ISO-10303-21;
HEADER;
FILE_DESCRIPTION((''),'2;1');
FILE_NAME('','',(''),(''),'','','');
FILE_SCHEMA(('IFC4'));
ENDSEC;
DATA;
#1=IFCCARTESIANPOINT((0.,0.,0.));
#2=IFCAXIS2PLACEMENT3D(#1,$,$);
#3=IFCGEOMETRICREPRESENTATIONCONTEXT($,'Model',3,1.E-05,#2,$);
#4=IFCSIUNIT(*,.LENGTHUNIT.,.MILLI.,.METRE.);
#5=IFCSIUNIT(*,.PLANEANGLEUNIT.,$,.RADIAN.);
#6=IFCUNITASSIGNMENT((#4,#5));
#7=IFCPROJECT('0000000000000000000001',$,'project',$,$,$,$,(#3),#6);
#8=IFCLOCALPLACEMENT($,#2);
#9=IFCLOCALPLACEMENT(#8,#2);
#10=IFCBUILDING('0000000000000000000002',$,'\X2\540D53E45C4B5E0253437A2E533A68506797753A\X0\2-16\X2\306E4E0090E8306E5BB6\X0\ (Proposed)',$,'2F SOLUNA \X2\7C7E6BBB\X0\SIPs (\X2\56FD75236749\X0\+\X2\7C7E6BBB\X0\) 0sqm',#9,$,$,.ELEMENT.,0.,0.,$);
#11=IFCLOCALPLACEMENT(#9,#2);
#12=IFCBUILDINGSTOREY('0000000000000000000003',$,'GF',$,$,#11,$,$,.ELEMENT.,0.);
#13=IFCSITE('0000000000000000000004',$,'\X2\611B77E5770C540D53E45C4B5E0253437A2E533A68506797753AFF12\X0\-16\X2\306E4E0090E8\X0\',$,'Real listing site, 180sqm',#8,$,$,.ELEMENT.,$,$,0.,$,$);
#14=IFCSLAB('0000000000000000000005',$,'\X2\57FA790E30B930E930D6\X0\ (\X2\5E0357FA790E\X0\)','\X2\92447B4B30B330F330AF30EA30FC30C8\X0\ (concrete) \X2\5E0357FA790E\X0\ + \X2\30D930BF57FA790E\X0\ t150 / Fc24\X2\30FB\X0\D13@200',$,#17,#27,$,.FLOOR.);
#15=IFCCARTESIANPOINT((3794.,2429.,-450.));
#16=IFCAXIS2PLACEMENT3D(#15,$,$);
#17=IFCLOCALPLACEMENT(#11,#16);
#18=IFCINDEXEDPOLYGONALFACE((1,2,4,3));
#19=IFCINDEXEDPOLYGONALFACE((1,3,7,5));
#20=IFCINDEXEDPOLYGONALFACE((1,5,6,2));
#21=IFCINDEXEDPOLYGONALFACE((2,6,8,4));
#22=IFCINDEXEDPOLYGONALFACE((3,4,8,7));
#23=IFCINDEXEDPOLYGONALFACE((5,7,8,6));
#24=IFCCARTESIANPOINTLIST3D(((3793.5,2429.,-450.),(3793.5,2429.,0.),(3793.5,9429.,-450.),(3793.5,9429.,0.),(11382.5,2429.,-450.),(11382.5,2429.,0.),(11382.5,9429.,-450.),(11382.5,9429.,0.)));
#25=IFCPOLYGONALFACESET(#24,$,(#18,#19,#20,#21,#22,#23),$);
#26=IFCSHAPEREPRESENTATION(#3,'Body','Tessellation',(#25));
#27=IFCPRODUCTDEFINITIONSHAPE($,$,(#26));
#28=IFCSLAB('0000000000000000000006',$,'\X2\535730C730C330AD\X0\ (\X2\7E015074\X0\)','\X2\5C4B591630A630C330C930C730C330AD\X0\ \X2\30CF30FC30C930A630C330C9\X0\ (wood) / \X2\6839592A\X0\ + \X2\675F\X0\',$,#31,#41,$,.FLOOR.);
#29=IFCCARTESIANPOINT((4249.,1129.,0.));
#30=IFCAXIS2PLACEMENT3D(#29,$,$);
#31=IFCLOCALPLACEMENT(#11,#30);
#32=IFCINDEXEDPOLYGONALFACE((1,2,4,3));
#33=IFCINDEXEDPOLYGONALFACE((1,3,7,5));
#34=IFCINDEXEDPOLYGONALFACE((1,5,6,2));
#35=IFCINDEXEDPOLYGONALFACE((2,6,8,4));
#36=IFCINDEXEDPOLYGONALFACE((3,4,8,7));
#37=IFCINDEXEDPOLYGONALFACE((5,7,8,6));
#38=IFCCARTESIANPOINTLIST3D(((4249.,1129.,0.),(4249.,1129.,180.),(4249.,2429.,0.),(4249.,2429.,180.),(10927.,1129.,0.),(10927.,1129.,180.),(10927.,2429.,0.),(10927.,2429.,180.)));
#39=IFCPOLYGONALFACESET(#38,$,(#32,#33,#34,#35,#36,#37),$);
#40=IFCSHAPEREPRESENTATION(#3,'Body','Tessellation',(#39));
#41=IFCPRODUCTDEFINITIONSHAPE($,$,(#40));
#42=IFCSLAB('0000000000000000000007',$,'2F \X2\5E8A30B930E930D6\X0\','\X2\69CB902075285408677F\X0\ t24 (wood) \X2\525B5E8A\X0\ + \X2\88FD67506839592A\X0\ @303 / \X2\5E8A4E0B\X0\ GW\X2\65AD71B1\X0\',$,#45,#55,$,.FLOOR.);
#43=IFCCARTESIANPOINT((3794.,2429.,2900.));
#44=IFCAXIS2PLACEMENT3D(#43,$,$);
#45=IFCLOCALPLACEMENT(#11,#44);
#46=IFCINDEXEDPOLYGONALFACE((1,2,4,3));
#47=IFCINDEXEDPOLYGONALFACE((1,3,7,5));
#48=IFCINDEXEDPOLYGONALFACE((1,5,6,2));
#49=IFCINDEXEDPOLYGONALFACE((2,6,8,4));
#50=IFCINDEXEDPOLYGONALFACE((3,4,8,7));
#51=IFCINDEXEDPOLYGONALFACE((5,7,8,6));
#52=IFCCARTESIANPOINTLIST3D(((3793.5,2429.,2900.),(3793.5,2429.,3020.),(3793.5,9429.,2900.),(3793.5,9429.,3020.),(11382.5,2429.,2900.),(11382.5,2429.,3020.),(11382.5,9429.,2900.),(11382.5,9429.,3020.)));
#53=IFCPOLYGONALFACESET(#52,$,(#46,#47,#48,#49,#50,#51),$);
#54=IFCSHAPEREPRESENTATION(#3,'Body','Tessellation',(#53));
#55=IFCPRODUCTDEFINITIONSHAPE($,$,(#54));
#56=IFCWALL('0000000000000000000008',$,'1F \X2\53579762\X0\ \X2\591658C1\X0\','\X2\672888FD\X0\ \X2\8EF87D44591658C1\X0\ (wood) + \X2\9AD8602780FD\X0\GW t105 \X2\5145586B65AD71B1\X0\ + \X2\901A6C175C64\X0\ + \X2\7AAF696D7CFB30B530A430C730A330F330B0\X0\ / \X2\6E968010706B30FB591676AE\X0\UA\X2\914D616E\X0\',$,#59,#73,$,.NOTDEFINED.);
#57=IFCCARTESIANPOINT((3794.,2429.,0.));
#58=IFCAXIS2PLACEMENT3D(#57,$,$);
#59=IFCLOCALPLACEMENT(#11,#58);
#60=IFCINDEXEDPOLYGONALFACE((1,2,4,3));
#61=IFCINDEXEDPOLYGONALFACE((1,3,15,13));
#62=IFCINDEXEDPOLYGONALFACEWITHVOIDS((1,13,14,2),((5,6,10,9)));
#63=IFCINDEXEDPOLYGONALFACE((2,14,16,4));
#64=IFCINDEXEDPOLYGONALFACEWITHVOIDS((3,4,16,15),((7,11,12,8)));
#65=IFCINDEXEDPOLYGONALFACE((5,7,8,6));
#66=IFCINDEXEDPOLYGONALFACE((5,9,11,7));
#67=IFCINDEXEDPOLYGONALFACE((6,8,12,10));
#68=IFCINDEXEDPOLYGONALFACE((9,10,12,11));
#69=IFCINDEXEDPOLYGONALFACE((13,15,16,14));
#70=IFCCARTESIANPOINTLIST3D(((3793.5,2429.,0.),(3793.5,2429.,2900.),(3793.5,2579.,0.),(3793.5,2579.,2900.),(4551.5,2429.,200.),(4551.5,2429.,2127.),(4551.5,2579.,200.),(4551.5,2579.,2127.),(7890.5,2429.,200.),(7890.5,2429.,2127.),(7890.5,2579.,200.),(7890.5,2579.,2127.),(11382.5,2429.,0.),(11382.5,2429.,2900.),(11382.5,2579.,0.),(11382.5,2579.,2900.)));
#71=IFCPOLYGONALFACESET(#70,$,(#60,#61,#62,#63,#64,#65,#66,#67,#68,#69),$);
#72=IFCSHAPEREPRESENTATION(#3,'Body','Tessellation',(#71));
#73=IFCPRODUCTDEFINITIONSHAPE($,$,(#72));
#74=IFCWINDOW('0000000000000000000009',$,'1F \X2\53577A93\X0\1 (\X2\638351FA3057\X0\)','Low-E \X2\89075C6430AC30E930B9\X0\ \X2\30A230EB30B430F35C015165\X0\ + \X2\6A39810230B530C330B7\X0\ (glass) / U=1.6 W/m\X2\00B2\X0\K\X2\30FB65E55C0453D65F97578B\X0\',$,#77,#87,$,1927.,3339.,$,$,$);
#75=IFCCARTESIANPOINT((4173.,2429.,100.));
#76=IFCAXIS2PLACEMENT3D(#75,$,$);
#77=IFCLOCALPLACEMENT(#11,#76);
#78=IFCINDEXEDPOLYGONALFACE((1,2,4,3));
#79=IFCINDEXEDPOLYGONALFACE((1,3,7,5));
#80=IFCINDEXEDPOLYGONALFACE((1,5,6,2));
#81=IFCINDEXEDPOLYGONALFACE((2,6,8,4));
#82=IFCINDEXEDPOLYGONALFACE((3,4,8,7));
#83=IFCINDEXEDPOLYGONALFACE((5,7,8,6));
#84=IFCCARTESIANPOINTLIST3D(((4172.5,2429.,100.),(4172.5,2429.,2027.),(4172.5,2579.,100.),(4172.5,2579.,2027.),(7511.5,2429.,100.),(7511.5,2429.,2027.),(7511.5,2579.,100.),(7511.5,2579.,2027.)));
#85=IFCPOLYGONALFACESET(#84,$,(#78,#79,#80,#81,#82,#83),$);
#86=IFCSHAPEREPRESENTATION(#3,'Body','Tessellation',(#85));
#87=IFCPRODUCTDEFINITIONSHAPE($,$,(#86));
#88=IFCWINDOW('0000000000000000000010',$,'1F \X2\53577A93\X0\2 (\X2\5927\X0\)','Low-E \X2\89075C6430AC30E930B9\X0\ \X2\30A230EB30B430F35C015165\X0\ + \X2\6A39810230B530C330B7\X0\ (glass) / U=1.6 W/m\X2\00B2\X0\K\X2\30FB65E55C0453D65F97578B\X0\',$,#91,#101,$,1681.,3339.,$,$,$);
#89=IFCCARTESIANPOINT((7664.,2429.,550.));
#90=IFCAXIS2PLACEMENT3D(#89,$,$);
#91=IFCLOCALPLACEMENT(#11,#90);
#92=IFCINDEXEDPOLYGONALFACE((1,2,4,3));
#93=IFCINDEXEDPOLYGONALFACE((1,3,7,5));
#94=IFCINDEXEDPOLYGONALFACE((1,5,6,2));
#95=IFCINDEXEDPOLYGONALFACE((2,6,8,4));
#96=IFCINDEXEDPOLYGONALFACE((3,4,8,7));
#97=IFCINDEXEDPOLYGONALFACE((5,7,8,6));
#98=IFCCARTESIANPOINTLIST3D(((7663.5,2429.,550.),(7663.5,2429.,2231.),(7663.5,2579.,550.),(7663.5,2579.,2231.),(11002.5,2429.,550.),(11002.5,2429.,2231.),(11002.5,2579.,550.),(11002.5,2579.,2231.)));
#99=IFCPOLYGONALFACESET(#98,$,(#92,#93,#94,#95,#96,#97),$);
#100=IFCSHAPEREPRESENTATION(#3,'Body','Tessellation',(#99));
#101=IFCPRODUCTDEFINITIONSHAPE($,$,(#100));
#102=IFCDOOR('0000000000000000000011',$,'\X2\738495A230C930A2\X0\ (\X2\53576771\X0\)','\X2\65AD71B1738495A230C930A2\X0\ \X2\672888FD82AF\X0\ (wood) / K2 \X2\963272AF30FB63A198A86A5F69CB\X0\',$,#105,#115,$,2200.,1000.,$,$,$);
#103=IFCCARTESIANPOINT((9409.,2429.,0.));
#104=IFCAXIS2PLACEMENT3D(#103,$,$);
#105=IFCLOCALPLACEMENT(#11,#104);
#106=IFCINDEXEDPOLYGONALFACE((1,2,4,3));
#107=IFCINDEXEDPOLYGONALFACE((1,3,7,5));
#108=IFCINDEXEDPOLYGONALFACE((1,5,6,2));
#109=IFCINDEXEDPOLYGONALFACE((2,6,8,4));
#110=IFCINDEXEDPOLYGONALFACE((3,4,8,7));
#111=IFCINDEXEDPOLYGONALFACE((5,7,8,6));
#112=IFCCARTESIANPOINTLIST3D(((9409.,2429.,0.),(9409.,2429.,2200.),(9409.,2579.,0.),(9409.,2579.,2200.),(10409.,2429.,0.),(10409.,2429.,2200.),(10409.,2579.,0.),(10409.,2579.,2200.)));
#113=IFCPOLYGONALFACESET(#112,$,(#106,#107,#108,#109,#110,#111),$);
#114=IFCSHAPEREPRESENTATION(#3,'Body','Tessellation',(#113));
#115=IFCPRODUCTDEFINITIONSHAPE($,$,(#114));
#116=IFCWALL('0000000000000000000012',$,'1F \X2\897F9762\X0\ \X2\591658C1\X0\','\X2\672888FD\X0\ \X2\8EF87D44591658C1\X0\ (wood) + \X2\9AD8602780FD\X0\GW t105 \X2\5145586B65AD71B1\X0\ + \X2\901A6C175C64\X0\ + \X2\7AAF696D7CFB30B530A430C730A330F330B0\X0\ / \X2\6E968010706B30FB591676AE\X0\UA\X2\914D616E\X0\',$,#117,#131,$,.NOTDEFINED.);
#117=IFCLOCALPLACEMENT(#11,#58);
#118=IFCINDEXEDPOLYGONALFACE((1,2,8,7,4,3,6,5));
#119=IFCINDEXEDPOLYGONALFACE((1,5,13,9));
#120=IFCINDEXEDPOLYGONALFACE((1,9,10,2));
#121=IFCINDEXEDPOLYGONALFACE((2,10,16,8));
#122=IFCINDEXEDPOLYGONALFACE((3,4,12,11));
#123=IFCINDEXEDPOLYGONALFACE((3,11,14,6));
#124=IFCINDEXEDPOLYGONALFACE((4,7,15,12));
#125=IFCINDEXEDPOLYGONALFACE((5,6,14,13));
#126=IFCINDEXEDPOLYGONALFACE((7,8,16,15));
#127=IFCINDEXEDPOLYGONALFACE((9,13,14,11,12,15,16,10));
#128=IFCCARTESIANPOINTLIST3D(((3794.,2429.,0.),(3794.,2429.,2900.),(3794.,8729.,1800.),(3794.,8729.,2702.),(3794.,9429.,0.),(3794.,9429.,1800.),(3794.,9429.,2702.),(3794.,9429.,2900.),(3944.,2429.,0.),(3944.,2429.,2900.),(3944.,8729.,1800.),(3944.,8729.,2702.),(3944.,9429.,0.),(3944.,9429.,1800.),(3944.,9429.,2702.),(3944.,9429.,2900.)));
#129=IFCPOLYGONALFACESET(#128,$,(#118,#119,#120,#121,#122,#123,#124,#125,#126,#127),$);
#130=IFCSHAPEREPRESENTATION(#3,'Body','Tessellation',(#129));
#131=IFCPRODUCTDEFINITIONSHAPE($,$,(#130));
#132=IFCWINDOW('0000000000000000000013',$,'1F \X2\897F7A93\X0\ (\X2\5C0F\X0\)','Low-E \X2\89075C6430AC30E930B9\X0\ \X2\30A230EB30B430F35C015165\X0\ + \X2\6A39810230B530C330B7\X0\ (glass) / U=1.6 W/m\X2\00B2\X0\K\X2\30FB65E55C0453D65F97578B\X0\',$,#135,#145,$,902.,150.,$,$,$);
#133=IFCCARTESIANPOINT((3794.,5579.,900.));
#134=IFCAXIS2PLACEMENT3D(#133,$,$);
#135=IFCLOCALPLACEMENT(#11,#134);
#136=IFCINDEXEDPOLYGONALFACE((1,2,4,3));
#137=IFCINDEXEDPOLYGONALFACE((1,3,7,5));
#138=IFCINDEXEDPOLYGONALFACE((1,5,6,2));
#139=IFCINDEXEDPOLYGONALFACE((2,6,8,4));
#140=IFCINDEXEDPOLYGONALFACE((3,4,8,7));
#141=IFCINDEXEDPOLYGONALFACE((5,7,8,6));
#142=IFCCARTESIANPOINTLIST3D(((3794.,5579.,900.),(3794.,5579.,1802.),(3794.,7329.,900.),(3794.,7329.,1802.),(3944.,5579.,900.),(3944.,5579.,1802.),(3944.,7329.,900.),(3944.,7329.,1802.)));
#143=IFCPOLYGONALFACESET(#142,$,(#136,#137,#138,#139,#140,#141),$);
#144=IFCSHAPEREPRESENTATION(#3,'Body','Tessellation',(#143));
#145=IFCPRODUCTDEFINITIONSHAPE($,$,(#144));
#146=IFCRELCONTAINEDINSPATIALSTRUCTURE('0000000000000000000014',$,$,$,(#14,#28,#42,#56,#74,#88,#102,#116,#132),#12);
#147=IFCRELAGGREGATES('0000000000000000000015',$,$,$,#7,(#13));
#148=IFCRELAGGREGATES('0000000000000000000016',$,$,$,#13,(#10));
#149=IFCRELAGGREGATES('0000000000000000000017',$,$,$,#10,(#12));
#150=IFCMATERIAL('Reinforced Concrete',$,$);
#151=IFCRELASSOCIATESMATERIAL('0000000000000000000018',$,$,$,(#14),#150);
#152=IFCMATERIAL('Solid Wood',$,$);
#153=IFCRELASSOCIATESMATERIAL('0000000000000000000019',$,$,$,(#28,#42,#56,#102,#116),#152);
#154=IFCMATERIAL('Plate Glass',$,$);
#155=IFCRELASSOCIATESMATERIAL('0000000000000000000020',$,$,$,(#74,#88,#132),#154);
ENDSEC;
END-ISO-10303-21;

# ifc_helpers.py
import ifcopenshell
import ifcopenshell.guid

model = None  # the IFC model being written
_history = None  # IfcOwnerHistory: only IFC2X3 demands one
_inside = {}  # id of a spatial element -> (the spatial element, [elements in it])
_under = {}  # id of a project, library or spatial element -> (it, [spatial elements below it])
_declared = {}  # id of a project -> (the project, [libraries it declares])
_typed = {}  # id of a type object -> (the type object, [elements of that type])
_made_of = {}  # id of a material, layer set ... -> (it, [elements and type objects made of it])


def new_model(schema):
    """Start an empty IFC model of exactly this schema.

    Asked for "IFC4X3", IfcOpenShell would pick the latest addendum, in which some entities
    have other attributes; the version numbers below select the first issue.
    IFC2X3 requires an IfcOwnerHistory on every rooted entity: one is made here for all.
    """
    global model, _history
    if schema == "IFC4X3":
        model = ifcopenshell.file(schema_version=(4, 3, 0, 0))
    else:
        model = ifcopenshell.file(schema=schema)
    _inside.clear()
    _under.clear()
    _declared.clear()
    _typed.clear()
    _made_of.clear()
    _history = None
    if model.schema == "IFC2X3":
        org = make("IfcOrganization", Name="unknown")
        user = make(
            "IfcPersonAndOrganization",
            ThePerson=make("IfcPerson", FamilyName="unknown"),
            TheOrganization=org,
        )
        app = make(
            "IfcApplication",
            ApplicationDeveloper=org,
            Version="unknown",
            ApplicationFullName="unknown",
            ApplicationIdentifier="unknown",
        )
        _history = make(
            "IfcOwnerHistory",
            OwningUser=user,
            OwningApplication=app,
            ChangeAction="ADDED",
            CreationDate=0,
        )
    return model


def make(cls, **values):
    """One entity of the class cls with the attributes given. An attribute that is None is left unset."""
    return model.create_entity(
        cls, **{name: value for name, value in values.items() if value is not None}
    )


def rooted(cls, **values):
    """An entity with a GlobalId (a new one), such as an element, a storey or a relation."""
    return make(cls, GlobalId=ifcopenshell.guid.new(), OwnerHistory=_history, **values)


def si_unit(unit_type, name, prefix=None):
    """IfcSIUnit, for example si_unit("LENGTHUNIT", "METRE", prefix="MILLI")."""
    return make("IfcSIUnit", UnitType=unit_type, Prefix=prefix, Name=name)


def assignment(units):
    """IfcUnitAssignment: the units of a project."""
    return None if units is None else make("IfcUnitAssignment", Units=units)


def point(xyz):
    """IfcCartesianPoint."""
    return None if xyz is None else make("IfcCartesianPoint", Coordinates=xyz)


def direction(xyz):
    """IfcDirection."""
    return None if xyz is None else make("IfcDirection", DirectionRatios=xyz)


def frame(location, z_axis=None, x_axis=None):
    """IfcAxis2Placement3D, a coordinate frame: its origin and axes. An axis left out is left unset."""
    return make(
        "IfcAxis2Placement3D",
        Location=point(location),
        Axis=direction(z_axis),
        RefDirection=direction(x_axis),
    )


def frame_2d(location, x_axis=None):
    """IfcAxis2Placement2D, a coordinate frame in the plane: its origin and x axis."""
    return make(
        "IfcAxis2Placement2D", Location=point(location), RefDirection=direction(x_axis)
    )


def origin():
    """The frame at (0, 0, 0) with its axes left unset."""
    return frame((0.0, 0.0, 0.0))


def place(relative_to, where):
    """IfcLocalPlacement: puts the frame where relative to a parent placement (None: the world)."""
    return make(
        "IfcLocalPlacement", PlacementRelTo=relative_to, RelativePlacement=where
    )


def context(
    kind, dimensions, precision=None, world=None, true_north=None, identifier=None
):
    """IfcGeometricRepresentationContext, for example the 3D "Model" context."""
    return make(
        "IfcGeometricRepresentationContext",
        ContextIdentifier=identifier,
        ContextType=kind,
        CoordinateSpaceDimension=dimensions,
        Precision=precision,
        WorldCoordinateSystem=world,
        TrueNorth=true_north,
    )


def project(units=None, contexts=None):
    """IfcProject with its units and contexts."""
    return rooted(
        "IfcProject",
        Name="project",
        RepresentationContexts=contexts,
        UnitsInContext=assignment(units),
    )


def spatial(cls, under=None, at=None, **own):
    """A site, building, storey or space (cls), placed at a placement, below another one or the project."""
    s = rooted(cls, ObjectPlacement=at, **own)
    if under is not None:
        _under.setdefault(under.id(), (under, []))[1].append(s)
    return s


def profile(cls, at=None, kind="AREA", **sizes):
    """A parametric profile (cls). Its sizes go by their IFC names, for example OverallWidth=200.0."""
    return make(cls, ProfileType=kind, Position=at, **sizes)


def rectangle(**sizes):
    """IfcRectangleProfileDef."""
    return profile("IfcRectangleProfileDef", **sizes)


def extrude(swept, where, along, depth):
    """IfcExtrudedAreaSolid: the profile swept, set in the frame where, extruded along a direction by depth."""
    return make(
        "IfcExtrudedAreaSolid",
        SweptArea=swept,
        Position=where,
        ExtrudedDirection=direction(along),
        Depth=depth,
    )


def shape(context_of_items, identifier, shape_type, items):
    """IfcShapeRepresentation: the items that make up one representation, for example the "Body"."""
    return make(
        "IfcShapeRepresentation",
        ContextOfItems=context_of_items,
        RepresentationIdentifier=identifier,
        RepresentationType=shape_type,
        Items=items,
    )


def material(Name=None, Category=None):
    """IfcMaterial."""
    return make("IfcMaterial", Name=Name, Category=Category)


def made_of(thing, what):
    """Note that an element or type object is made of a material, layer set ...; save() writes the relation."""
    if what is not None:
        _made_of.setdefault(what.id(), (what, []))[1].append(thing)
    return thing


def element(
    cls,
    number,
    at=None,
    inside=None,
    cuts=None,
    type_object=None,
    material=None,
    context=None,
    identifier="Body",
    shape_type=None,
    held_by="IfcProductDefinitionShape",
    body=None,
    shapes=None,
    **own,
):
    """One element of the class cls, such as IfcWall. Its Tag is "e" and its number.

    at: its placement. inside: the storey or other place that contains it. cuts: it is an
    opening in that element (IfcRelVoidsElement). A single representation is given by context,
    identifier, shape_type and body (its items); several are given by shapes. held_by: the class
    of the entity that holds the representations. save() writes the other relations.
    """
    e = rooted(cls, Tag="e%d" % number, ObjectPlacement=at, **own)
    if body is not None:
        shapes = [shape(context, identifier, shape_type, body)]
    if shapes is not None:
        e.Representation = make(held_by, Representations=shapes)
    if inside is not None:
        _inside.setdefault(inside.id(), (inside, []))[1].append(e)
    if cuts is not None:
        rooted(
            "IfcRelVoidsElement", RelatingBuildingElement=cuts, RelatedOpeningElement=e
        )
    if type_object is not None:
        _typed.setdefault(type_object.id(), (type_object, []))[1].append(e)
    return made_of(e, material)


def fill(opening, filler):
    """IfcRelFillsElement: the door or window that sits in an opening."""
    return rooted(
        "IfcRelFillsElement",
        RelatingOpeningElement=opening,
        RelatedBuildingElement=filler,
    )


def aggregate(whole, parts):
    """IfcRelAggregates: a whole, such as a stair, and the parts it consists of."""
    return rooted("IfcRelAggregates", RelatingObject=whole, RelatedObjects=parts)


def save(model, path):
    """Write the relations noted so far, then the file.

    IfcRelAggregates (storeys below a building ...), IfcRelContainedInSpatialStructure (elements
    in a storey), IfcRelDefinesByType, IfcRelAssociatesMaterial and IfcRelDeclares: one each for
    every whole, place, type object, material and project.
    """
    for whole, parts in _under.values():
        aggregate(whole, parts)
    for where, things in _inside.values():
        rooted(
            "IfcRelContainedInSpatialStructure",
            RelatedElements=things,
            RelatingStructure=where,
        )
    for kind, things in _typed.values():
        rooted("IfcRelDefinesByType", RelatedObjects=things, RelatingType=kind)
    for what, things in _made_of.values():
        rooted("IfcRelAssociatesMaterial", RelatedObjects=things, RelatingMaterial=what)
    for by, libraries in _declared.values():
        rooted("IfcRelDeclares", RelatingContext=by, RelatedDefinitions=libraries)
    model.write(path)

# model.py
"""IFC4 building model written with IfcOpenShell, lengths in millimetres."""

from ifc_helpers import new_model, si_unit, frame, frame_2d, origin, place, context, project, spatial, rectangle, extrude, material, element, fill, save


model = new_model("IFC4")

# Units and contexts
model_context = context("Model", 3, precision=1e-05, world=origin())
ifc_project = project(units=[si_unit("LENGTHUNIT", "METRE", prefix="MILLI"), si_unit("PLANEANGLEUNIT", "RADIAN")], contexts=[model_context])

# Site, building, storey
site_placement = place(None, origin())
site = spatial("IfcSite", under=ifc_project, at=site_placement, Name="愛知県名古屋市千種区桐林町２-16の一部", ObjectType="Real listing site, 180sqm", CompositionType="ELEMENT", RefElevation=0.0)
building_placement = place(site_placement, origin())
building = spatial("IfcBuilding", under=site, at=building_placement, Name="名古屋市千種区桐林町2-16の一部の家 (Proposed)", ObjectType="2F SOLUNA 籾殻SIPs (国産杉+籾殻) 0sqm", CompositionType="ELEMENT", ElevationOfRefHeight=0.0, ElevationOfTerrain=0.0)
storey_placement = place(building_placement, origin())
storey = spatial("IfcBuildingStorey", under=building, at=storey_placement, Name="GF", CompositionType="ELEMENT", Elevation=0.0)

# Slabs
ifc_material_1 = material(Name="Reinforced Concrete")
slab_1_placement = place(storey_placement, frame((3794.0, 2429.0, -450.0)))
element("IfcSlab", 1, at=slab_1_placement, inside=storey, material=ifc_material_1, Name="基礎スラブ (布基礎)", Description="鉄筋コンクリート (concrete) 布基礎 + ベタ基礎 t150 / Fc24・D13@200", PredefinedType="FLOOR", context=model_context, shape_type="SweptSolid", body=[
    extrude(rectangle(XDim=7589.0, YDim=7000.0, at=frame_2d((3794.0, 3500.0))), frame((3794.0, 2429.0, -450.0)), (0.0, 0.0, 1.0), 450.0),
])
ifc_material_2 = material(Name="Solid Wood")
slab_2_placement = place(storey_placement, frame((4249.0, 1129.0, 0.0)))
element("IfcSlab", 2, at=slab_2_placement, inside=storey, material=ifc_material_2, Name="南デッキ (縁側)", Description="屋外ウッドデッキ ハードウッド (wood) / 根太 + 束", PredefinedType="FLOOR", context=model_context, shape_type="SweptSolid", body=[
    extrude(rectangle(XDim=6678.0, YDim=1300.0, at=frame_2d((3339.0, 650.0))), frame((4249.0, 1129.0, 0.0)), (0.0, 0.0, 1.0), 180.0),
])
slab_3_placement = place(storey_placement, frame((3794.0, 2429.0, 2900.0)))
element("IfcSlab", 3, at=slab_3_placement, inside=storey, material=ifc_material_2, Name="2F 床スラブ", Description="構造用合板 t24 (wood) 剛床 + 製材根太 @303 / 床下 GW断熱", PredefinedType="FLOOR", context=model_context, shape_type="SweptSolid", body=[
    extrude(rectangle(XDim=7589.0, YDim=7000.0, at=frame_2d((3794.0, 3500.0))), frame((3794.0, 2429.0, 2900.0)), (0.0, 0.0, 1.0), 120.0),
])

# Wall, openings, windows, door
wall_1_placement = place(storey_placement, frame((3794.0, 2429.0, 0.0)))
wall_1 = element("IfcWall", 4, at=wall_1_placement, inside=storey, material=ifc_material_2, Name="1F 南面 外壁", Description="木製 軸組外壁 (wood) + 高性能GW t105 充填断熱 + 通気層 + 窯業系サイディング / 準耐火・外皮UA配慮", PredefinedType="NOTDEFINED", context=model_context, shape_type="SweptSolid", body=[
    extrude(rectangle(XDim=7589.0, YDim=150.0, at=frame_2d((3794.0, 75.0))), frame((3794.0, 2429.0, 0.0)), (0.0, 0.0, 1.0), 2900.0),
])
opening_1_placement = place(storey_placement, frame((4173.0, 2429.0, 100.0)))
opening_1 = element("IfcOpeningElement", 5, at=opening_1_placement, cuts=wall_1, PredefinedType="NOTDEFINED", context=model_context, shape_type="SweptSolid", body=[
    extrude(rectangle(XDim=3339.0, YDim=150.0, at=frame_2d((1669.0, 75.0))), frame((4173.0, 2429.0, 100.0)), (0.0, 0.0, 1.0), 1927.0),
])
opening_2_placement = place(storey_placement, frame((7664.0, 2429.0, 550.0)))
opening_2 = element("IfcOpeningElement", 6, at=opening_2_placement, cuts=wall_1, PredefinedType="NOTDEFINED", context=model_context, shape_type="SweptSolid", body=[
    extrude(rectangle(XDim=3339.0, YDim=150.0, at=frame_2d((1669.0, 75.0))), frame((7664.0, 2429.0, 550.0)), (0.0, 0.0, 1.0), 1681.0),
])
opening_3_placement = place(storey_placement, frame((9409.0, 2429.0, 0.0)))
opening_3 = element("IfcOpeningElement", 7, at=opening_3_placement, cuts=wall_1, PredefinedType="NOTDEFINED", context=model_context, shape_type="SweptSolid", body=[
    extrude(rectangle(XDim=1000.0, YDim=150.0, at=frame_2d((500.0, 75.0))), frame((9409.0, 2429.0, 0.0)), (0.0, 0.0, 1.0), 2200.0),
])
ifc_material_3 = material(Name="Plate Glass")
window_1_placement = place(storey_placement, frame((4173.0, 2429.0, 100.0)))
window_1 = element("IfcWindow", 8, at=window_1_placement, inside=storey, material=ifc_material_3, Name="1F 南窓1 (掃出し)", Description="Low-E 複層ガラス アルゴン封入 + 樹脂サッシ (glass) / U=1.6 W/m²K・日射取得型", OverallHeight=1927.0, OverallWidth=3339.0, context=model_context, shape_type="SweptSolid", body=[
    extrude(rectangle(XDim=3339.0, YDim=150.0, at=frame_2d((1669.0, 75.0))), frame((4173.0, 2429.0, 100.0)), (0.0, 0.0, 1.0), 1927.0),
])
fill(opening_1, window_1)
window_2_placement = place(storey_placement, frame((7664.0, 2429.0, 550.0)))
window_2 = element("IfcWindow", 9, at=window_2_placement, inside=storey, material=ifc_material_3, Name="1F 南窓2 (大)", Description="Low-E 複層ガラス アルゴン封入 + 樹脂サッシ (glass) / U=1.6 W/m²K・日射取得型", OverallHeight=1681.0, OverallWidth=3339.0, context=model_context, shape_type="SweptSolid", body=[
    extrude(rectangle(XDim=3339.0, YDim=150.0, at=frame_2d((1669.0, 75.0))), frame((7664.0, 2429.0, 550.0)), (0.0, 0.0, 1.0), 1681.0),
])
fill(opening_2, window_2)
door_placement = place(storey_placement, frame((9409.0, 2429.0, 0.0)))
door = element("IfcDoor", 10, at=door_placement, inside=storey, material=ifc_material_2, Name="玄関ドア (南東)", Description="断熱玄関ドア 木製芯 (wood) / K2 防犯・採風機構", OverallHeight=2200.0, OverallWidth=1000.0, context=model_context, shape_type="SweptSolid", body=[
    extrude(rectangle(XDim=1000.0, YDim=150.0, at=frame_2d((500.0, 75.0))), frame((9409.0, 2429.0, 0.0)), (0.0, 0.0, 1.0), 2200.0),
])
fill(opening_3, door)

# Wall, opening, window
wall_2_placement = place(storey_placement, frame((3794.0, 2429.0, 0.0)))
wall_2 = element("IfcWall", 11, at=wall_2_placement, inside=storey, material=ifc_material_2, Name="1F 西面 外壁", Description="木製 軸組外壁 (wood) + 高性能GW t105 充填断熱 + 通気層 + 窯業系サイディング / 準耐火・外皮UA配慮", PredefinedType="NOTDEFINED", context=model_context, shape_type="SweptSolid", body=[
    extrude(rectangle(XDim=150.0, YDim=7000.0, at=frame_2d((75.0, 3500.0))), frame((3794.0, 2429.0, 0.0)), (0.0, 0.0, 1.0), 2900.0),
])
opening_4_placement = place(storey_placement, frame((3794.0, 5579.0, 900.0)))
opening_4 = element("IfcOpeningElement", 12, at=opening_4_placement, cuts=wall_2, PredefinedType="NOTDEFINED", context=model_context, shape_type="SweptSolid", body=[
    extrude(rectangle(XDim=150.0, YDim=1750.0, at=frame_2d((75.0, 875.0))), frame((3794.0, 5579.0, 900.0)), (0.0, 0.0, 1.0), 902.0),
])
window_3_placement = place(storey_placement, frame((3794.0, 5579.0, 900.0)))
window_3 = element("IfcWindow", 13, at=window_3_placement, inside=storey, material=ifc_material_3, Name="1F 西窓 (小)", Description="Low-E 複層ガラス アルゴン封入 + 樹脂サッシ (glass) / U=1.6 W/m²K・日射取得型", OverallHeight=902.0, OverallWidth=150.0, context=model_context, shape_type="SweptSolid", body=[
    extrude(rectangle(XDim=150.0, YDim=1750.0, at=frame_2d((75.0, 875.0))), frame((3794.0, 5579.0, 900.0)), (0.0, 0.0, 1.0), 902.0),
])
fill(opening_4, window_3)

save(model, "model.ifc")
